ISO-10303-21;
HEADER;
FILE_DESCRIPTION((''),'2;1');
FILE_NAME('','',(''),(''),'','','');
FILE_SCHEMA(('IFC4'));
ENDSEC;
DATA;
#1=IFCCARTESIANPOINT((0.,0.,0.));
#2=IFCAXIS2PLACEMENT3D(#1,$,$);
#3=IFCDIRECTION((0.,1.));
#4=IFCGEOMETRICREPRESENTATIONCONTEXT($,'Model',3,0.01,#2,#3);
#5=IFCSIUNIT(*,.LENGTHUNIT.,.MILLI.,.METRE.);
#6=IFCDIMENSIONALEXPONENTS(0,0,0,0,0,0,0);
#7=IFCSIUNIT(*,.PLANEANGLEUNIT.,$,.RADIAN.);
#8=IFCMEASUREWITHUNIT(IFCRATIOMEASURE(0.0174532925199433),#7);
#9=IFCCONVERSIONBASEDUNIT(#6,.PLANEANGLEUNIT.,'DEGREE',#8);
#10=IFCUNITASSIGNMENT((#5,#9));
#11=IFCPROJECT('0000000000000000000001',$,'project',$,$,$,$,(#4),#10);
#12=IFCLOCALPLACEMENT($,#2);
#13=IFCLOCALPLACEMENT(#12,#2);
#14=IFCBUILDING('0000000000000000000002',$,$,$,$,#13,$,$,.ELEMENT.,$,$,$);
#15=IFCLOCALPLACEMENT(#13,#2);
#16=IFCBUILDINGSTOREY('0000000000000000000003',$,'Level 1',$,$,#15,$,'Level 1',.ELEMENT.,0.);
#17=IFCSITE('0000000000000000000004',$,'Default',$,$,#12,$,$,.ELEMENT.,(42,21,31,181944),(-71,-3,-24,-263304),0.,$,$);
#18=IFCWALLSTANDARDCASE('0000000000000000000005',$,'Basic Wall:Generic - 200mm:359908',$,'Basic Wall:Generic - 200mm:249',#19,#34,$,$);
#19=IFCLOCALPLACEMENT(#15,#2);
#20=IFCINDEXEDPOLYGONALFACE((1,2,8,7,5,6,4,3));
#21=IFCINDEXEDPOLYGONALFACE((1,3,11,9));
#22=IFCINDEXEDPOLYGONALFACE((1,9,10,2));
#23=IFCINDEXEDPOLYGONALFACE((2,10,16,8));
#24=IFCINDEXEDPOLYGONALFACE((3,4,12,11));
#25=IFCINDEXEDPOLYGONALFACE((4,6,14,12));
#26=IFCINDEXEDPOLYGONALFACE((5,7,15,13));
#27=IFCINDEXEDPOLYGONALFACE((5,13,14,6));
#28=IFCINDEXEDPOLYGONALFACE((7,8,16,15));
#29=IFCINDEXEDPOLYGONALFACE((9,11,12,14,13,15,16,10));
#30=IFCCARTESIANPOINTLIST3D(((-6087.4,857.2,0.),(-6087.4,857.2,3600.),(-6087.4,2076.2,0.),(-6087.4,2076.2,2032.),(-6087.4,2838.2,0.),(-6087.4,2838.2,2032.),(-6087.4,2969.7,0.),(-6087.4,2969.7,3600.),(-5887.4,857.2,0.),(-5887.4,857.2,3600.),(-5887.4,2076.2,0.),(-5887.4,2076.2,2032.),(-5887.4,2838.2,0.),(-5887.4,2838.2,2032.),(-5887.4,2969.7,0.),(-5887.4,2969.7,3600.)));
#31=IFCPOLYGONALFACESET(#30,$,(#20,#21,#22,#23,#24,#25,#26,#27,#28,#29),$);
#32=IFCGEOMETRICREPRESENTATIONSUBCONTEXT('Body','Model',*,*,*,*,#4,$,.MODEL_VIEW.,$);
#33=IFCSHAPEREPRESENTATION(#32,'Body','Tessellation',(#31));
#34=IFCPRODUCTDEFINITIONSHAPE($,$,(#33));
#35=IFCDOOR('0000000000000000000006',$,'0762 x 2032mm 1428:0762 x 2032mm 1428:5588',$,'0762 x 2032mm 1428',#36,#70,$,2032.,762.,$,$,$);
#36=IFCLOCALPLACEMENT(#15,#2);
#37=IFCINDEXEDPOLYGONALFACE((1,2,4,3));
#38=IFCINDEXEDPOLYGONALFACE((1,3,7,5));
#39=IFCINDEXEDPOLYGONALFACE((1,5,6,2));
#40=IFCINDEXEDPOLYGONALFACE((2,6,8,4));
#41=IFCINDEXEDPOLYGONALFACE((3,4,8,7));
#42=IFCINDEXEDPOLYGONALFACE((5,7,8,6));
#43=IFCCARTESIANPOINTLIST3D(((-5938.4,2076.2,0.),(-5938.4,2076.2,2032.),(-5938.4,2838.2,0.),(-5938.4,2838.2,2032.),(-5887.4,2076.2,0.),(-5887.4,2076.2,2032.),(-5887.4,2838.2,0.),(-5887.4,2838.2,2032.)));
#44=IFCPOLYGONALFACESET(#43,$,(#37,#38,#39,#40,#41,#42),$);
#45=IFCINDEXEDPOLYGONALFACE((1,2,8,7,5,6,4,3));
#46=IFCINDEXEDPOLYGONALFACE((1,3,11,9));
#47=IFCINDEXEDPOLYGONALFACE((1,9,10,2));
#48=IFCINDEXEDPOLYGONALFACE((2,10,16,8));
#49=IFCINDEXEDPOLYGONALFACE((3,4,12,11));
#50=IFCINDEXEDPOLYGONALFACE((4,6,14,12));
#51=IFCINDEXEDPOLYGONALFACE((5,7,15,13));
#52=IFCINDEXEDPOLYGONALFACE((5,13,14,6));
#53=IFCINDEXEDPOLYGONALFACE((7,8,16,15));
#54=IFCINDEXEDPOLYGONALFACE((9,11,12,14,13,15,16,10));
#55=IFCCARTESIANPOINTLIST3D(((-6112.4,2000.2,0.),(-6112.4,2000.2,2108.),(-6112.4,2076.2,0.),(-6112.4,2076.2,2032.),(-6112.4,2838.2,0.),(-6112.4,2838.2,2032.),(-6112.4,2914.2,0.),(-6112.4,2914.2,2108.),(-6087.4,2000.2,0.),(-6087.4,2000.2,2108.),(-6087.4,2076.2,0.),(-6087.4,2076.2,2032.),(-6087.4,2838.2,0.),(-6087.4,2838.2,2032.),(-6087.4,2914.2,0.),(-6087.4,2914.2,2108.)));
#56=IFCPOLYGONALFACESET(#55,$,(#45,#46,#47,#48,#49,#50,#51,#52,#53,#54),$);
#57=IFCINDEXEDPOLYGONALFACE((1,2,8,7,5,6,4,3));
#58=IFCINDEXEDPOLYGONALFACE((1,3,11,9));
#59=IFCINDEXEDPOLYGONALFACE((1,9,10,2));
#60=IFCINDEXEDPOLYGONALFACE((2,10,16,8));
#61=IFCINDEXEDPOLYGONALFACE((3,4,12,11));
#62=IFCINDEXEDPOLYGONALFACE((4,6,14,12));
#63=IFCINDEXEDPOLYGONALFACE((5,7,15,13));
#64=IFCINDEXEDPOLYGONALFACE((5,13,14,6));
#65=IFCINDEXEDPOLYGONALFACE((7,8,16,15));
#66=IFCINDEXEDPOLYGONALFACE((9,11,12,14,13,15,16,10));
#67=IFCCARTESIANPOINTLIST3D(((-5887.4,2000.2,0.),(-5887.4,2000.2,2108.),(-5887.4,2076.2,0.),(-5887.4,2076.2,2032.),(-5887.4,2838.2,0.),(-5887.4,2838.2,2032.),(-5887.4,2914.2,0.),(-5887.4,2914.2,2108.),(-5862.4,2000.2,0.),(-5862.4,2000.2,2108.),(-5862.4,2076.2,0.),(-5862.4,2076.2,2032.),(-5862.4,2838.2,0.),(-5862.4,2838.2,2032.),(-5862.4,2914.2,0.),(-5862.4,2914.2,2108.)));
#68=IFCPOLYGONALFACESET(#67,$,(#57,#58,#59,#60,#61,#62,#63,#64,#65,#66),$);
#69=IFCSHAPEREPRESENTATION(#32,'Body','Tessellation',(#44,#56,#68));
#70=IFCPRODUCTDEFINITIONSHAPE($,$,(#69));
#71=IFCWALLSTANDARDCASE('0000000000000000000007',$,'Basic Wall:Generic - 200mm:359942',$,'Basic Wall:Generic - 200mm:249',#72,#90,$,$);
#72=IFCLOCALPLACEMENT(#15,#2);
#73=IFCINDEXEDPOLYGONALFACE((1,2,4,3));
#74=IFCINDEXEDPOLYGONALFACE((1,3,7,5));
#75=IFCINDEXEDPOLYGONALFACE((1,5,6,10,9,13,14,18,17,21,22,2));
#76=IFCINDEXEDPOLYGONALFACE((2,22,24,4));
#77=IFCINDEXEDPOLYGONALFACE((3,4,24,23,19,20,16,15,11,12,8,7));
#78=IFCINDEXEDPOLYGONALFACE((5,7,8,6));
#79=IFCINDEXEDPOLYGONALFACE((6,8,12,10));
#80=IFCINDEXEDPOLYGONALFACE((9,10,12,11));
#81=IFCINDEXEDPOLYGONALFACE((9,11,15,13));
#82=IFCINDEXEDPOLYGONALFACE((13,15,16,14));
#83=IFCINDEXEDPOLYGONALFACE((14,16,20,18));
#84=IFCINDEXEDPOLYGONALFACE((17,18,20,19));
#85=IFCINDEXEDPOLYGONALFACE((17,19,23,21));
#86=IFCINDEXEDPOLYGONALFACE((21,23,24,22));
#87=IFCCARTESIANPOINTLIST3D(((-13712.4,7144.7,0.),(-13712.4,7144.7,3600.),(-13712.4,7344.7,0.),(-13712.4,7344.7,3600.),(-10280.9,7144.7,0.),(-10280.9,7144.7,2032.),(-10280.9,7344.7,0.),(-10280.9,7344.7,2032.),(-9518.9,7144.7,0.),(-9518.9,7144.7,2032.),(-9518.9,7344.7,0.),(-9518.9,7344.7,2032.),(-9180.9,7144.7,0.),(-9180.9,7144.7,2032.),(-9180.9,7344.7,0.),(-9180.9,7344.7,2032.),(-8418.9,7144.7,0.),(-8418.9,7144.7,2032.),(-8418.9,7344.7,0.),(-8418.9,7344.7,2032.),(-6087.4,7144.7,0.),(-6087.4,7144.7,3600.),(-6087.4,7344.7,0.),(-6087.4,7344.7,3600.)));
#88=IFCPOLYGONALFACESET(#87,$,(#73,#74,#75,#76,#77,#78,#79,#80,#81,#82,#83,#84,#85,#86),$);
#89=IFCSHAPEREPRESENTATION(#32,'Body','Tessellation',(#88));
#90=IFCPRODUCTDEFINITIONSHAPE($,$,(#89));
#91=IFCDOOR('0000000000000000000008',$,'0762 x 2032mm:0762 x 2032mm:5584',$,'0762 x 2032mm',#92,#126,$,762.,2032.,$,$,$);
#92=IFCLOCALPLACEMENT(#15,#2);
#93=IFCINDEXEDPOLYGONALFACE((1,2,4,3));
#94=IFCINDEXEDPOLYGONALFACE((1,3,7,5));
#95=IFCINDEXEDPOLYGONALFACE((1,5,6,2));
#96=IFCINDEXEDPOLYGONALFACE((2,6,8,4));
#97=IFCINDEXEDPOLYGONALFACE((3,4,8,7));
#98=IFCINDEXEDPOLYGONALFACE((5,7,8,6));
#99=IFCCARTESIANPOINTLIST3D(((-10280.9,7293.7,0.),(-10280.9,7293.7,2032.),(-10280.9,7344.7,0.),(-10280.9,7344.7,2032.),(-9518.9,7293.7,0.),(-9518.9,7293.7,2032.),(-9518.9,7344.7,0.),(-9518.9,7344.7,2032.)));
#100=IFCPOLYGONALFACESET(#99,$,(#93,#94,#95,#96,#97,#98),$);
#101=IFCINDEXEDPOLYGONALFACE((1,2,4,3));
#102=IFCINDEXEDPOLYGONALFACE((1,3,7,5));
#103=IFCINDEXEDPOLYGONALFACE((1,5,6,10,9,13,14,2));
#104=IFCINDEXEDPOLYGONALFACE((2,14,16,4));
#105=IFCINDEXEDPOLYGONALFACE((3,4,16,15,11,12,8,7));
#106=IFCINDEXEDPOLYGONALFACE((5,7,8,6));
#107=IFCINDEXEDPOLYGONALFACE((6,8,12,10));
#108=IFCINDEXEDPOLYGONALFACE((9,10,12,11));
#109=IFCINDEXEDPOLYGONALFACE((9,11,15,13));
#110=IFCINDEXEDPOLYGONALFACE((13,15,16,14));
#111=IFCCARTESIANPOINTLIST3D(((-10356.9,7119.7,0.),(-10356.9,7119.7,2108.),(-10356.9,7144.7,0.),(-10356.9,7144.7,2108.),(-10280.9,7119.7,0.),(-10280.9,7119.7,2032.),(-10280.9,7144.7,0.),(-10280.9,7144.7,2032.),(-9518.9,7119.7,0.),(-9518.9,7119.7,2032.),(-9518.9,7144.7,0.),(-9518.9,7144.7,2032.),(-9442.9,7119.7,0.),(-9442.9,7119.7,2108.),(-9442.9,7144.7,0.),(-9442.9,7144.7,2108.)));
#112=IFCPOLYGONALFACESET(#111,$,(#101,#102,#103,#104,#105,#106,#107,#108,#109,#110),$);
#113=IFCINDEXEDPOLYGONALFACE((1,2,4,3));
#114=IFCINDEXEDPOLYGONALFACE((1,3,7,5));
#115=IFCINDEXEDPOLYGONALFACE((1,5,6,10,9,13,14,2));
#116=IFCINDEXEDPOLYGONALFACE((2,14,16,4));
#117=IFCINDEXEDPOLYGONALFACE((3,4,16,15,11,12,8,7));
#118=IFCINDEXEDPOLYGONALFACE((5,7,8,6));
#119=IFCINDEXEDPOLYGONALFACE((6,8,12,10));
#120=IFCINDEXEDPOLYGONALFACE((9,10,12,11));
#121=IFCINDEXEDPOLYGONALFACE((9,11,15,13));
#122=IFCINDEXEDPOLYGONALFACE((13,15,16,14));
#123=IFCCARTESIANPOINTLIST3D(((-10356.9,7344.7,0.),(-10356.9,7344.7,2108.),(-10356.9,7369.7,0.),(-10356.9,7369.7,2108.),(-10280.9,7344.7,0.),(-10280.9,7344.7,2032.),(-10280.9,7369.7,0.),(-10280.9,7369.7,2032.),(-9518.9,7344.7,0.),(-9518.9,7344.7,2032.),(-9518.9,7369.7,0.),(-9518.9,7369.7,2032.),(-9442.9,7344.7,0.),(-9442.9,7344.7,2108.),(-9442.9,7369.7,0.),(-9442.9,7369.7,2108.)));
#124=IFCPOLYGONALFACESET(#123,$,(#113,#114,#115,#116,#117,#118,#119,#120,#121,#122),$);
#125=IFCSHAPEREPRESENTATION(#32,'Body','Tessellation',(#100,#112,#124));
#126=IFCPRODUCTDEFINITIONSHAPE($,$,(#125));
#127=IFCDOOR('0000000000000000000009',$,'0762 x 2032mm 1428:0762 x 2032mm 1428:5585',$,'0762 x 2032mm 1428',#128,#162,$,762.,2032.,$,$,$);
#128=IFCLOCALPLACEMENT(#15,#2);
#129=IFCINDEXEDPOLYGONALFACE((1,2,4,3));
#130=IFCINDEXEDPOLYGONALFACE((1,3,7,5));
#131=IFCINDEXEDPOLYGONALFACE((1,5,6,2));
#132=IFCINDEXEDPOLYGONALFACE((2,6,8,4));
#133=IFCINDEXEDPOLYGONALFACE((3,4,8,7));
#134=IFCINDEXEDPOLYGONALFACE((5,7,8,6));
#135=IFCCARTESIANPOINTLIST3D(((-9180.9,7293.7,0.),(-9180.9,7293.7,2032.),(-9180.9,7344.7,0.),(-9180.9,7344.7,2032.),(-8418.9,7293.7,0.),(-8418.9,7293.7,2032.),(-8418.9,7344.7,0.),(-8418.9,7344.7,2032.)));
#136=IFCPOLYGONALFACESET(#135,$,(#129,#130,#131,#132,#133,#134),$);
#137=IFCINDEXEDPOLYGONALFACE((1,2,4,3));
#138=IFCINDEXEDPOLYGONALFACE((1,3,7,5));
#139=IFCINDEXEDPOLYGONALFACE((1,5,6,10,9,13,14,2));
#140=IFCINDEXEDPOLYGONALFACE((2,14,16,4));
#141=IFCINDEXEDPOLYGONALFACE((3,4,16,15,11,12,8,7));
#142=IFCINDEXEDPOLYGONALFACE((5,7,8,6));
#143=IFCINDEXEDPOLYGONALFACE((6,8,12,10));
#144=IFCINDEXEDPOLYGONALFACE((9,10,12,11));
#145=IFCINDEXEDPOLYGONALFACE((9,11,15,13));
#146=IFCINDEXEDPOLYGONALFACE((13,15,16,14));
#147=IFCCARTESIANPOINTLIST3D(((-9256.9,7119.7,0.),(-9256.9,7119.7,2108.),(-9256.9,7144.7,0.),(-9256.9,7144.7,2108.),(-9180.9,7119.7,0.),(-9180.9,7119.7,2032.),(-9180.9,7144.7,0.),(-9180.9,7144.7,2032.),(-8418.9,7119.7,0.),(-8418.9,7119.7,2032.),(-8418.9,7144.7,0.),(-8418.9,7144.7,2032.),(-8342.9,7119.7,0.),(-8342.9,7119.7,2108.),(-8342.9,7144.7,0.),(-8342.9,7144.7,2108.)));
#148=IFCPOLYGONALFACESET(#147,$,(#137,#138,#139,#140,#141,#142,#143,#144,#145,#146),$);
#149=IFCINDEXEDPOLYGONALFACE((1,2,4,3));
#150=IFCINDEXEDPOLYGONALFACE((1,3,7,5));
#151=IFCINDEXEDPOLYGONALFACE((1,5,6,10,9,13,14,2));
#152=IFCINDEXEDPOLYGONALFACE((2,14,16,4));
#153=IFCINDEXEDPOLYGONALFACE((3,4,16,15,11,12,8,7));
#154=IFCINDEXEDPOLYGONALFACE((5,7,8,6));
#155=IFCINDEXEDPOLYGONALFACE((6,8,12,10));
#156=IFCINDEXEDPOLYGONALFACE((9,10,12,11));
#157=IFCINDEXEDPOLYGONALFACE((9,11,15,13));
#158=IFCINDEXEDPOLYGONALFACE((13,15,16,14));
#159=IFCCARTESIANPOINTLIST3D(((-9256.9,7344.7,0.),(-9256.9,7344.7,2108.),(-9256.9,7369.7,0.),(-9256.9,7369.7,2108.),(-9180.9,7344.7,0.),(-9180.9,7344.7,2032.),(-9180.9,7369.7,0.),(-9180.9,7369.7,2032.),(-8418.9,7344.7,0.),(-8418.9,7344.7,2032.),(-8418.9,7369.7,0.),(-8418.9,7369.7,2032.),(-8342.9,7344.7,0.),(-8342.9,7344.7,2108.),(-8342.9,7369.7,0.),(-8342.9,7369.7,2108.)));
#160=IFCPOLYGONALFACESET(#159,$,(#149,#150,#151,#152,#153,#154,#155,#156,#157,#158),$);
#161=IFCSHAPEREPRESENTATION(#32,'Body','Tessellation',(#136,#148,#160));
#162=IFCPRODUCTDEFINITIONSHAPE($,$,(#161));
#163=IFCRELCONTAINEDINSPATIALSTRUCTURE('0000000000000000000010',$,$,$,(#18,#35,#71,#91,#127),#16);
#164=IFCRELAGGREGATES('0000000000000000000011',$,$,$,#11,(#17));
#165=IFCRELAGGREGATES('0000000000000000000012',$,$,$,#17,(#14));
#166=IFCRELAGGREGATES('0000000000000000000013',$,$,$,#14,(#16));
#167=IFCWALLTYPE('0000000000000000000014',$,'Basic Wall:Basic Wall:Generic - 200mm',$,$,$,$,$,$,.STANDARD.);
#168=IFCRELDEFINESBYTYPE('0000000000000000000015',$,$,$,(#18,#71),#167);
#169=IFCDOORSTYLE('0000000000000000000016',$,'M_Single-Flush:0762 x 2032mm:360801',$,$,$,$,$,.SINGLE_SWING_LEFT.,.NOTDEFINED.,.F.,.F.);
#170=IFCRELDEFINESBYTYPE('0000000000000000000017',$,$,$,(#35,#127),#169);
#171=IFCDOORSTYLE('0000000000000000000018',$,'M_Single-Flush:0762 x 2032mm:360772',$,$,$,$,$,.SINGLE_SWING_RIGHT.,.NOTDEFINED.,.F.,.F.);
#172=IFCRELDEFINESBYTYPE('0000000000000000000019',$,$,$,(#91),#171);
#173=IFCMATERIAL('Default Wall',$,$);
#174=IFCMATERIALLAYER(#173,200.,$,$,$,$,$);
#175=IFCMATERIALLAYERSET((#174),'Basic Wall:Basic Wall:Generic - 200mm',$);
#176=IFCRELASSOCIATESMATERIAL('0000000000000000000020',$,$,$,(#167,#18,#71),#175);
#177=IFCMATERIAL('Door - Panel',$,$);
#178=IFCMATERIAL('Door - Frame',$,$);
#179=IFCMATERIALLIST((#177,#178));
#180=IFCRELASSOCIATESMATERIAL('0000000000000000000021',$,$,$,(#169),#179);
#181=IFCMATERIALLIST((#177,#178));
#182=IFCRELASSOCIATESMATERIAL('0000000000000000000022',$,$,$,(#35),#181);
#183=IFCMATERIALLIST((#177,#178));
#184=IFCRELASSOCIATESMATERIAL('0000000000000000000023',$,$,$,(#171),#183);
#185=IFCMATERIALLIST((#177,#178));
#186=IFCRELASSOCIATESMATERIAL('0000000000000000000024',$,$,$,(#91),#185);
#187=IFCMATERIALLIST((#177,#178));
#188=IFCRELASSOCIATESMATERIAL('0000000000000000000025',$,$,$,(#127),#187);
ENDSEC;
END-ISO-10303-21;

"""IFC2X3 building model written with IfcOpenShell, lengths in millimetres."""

from ifc_helpers import new_model, entity, si_unit, converted_unit, direction, frame, frame_2d, origin, origin_2d_with_axis, place, context, subcontext, project, spatial, polyline, rectangle, outline, extrude, source, transform, mapped, material, material_list, layer, layer_set, layer_usage, type_object, type_shapes, element, fill, save


model = new_model("IFC2X3")

# Units and contexts
model_context = context("Model", 3, precision=0.01, world=origin(), true_north=direction((0.0, 1.0)))
body_context = subcontext(model_context, "Body", "Model", "MODEL_VIEW")
ifc_project = project(units=[si_unit("LENGTHUNIT", "METRE", prefix="MILLI"), converted_unit("PLANEANGLEUNIT", "DEGREE", entity("IfcRatioMeasure", 0.0174532925199433), si_unit("PLANEANGLEUNIT", "RADIAN"), dimensions=[0, 0, 0, 0, 0, 0, 0])], contexts=[model_context])

# Site, building, storey
site_placement = place(None, origin())
site = spatial("IfcSite", under=ifc_project, at=site_placement, Name="Default", CompositionType="ELEMENT", RefLatitude=(42, 21, 31, 181944), RefLongitude=(-71, -3, -24, -263304), RefElevation=0.0)
building_placement = place(site_placement, origin())
building = spatial("IfcBuilding", under=site, at=building_placement, CompositionType="ELEMENT")
storey_placement = place(building_placement, origin())
storey = spatial("IfcBuildingStorey", under=building, at=storey_placement, Name="Level 1", LongName="Level 1", CompositionType="ELEMENT", Elevation=0.0)

# Shared definitions
ifc_material_1 = material(Name="Default Wall")
ifc_material_2 = material(Name="Door - Panel")
ifc_material_3 = material(Name="Door - Frame")

# Wall, opening, door
ifc_layer_1 = layer(ifc_material_1, 200.0)
ifc_layer_set_1 = layer_set([ifc_layer_1], Name="Basic Wall:Basic Wall:Generic - 200mm")
ifc_layer_usage_1 = layer_usage(ifc_layer_set_1, "AXIS2", "NEGATIVE", 100.0)
wall_type_1 = type_object("IfcWallType", Name="Basic Wall:Basic Wall:Generic - 200mm", PredefinedType="STANDARD", material=ifc_layer_set_1)
wall_1_placement = place(storey_placement, frame((-5987.4, 857.2, 0.0), z_axis=(0.0, 0.0, 1.0), x_axis=(0.0, 1.0, 0.0)))
wall_1 = element("IfcWallStandardCase", 1, at=wall_1_placement, inside=storey, type_object=wall_type_1, material=ifc_layer_usage_1, Name="Basic Wall:Generic - 200mm:359908", ObjectType="Basic Wall:Generic - 200mm:249", context=body_context, shape_type="SweptSolid", body=[
    extrude(rectangle(XDim=2112.5, YDim=200.0, at=frame_2d((1056.2, 0.0), x_axis=(-1.0, 0.0))), origin(), (0.0, 0.0, 1.0), 3600.0),
])
opening_1_placement = place(wall_1_placement, frame((-857.2, -5987.4, 0.0), z_axis=(0.0, 0.0, 1.0), x_axis=(0.0, -1.0, 0.0)))
opening_1 = element("IfcOpeningElement", 2, at=opening_1_placement, cuts=wall_1, ObjectType="Opening", context=body_context, shape_type="SweptSolid", body=[
    extrude(rectangle(XDim=2032.0, YDim=762.0, at=frame_2d((0.0, 0.0), x_axis=(0.0, 1.0))), frame((-5885.4, 2457.2, 1016.0), z_axis=(-1.0, 0.0, 0.0), x_axis=(0.0, -1.0, 0.0)), (0.0, 0.0, 1.0), 204.0),
])
ifc_material_list_1 = material_list([ifc_material_2, ifc_material_3])
ifc_material_list_2 = material_list([ifc_material_2, ifc_material_3])
door_style_1 = type_object("IfcDoorStyle", Name="M_Single-Flush:0762 x 2032mm:360801", ConstructionType="NOTDEFINED", OperationType="SINGLE_SWING_LEFT", ParameterTakesPrecedence=False, Sizeable=False, material=ifc_material_list_2)
shared_shape_1 = source(origin(), body_context, "Body", "SweptSolid", [
    extrude(rectangle(XDim=51.0, YDim=762.0, at=origin_2d_with_axis()), frame((381.0, -27.5, 0.0), z_axis=(0.0, 0.0, 1.0), x_axis=(0.0, 1.0, 0.0)), (0.0, 0.0, 1.0), 2032.0),
    extrude(outline(polyline([(-1035.0, -457.0), (1073.0, -457.0), (1073.0, 457.0), (-1035.0, 457.0), (-1035.0, 381.0), (997.0, 381.0), (997.0, -381.0), (-1035.0, -381.0), (-1035.0, -457.0)])), frame((381.0, -227.0, 1035.0), z_axis=(0.0, 1.0, 0.0), x_axis=(0.0, 0.0, 1.0)), (0.0, 0.0, 1.0), 25.0),
    extrude(outline(polyline([(-457.0, -1073.0), (457.0, -1073.0), (457.0, 1035.0), (381.0, 1035.0), (381.0, -997.0), (-381.0, -997.0), (-381.0, 1035.0), (-457.0, 1035.0), (-457.0, -1073.0)])), frame((381.0, -2.0, 1035.0), z_axis=(0.0, 1.0, 0.0), x_axis=(1.0, 0.0, 0.0)), (0.0, 0.0, 1.0), 25.0),
])
type_shapes(door_style_1, [shared_shape_1])
door_1_placement = place(opening_1_placement, frame((-5885.4, 2838.2, 0.0), z_axis=(0.0, 0.0, 1.0), x_axis=(0.0, -1.0, 0.0)))
door_1 = element("IfcDoor", 3, at=door_1_placement, inside=storey, type_object=door_style_1, material=ifc_material_list_1, Name="0762 x 2032mm 1428:0762 x 2032mm 1428:5588", ObjectType="0762 x 2032mm 1428", OverallHeight=2032.0, OverallWidth=762.0, context=body_context, shape_type="MappedRepresentation", body=[
    mapped(shared_shape_1, transform((0.0, 0.0, 0.0), scale=1.0)),
])
fill(opening_1, door_1)

# Wall, openings, doors
ifc_layer_usage_2 = layer_usage(ifc_layer_set_1, "AXIS2", "NEGATIVE", 100.0)
wall_2_placement = place(storey_placement, frame((-13712.4, 7244.7, 0.0)))
wall_2 = element("IfcWallStandardCase", 4, at=wall_2_placement, inside=storey, type_object=wall_type_1, material=ifc_layer_usage_2, Name="Basic Wall:Generic - 200mm:359942", ObjectType="Basic Wall:Generic - 200mm:249", context=body_context, shape_type="SweptSolid", body=[
    extrude(rectangle(XDim=7625.0, YDim=200.0, at=frame_2d((3812.5, 0.0), x_axis=(-1.0, 0.0))), origin(), (0.0, 0.0, 1.0), 3600.0),
])
opening_2_placement = place(wall_2_placement, frame((13712.4, -7244.7, 0.0)))
opening_2 = element("IfcOpeningElement", 5, at=opening_2_placement, cuts=wall_2, ObjectType="Opening", context=body_context, shape_type="SweptSolid", body=[
    extrude(rectangle(XDim=2032.0, YDim=762.0, at=origin_2d_with_axis()), frame((-9899.9, 7142.7, 1016.0), z_axis=(0.0, 1.0, 0.0), x_axis=(0.0, 0.0, -1.0)), (0.0, 0.0, 1.0), 204.0),
])
opening_3_placement = place(wall_2_placement, frame((13712.4, -7244.7, 0.0)))
opening_3 = element("IfcOpeningElement", 6, at=opening_3_placement, cuts=wall_2, ObjectType="Opening", context=body_context, shape_type="SweptSolid", body=[
    extrude(rectangle(XDim=2032.0, YDim=762.0, at=origin_2d_with_axis()), frame((-8799.9, 7142.7, 1016.0), z_axis=(0.0, 1.0, 0.0), x_axis=(0.0, 0.0, 1.0)), (0.0, 0.0, 1.0), 204.0),
])
ifc_material_list_3 = material_list([ifc_material_2, ifc_material_3])
ifc_material_list_4 = material_list([ifc_material_2, ifc_material_3])
door_style_2 = type_object("IfcDoorStyle", Name="M_Single-Flush:0762 x 2032mm:360772", ConstructionType="NOTDEFINED", OperationType="SINGLE_SWING_RIGHT", ParameterTakesPrecedence=False, Sizeable=False, material=ifc_material_list_4)
shared_shape_2 = source(origin(), body_context, "Body", "SweptSolid", [
    extrude(rectangle(XDim=762.0, YDim=51.0, at=frame_2d((0.0, 0.0), x_axis=(1.0, 0.0))), frame((381.0, -27.5, 0.0), z_axis=(0.0, 0.0, 1.0), x_axis=(-1.0, 0.0, 0.0)), (0.0, 0.0, 1.0), 2032.0),
    extrude(outline(polyline([(-457.0, -1035.0), (-381.0, -1035.0), (-381.0, 997.0), (381.0, 997.0), (381.0, -1035.0), (457.0, -1035.0), (457.0, 1073.0), (-457.0, 1073.0), (-457.0, -1035.0)])), frame((381.0, -227.0, 1035.0), z_axis=(0.0, 1.0, 0.0), x_axis=(-1.0, 0.0, 0.0)), (0.0, 0.0, 1.0), 25.0),
    extrude(outline(polyline([(-1073.0, -457.0), (1035.0, -457.0), (1035.0, -381.0), (-997.0, -381.0), (-997.0, 381.0), (1035.0, 381.0), (1035.0, 457.0), (-1073.0, 457.0), (-1073.0, -457.0)])), frame((381.0, -2.0, 1035.0), z_axis=(0.0, 1.0, 0.0), x_axis=(0.0, 0.0, -1.0)), (0.0, 0.0, 1.0), 25.0),
])
type_shapes(door_style_2, [shared_shape_2])
door_2_placement = place(opening_2_placement, frame((-10280.9, 7346.7, 0.0)))
door_2 = element("IfcDoor", 7, at=door_2_placement, inside=storey, type_object=door_style_2, material=ifc_material_list_3, Name="0762 x 2032mm:0762 x 2032mm:5584", ObjectType="0762 x 2032mm", OverallHeight=762.0, OverallWidth=2032.0, context=body_context, shape_type="MappedRepresentation", body=[
    mapped(shared_shape_2, transform((0.0, 0.0, 0.0), scale=1.0)),
])
fill(opening_2, door_2)
ifc_material_list_5 = material_list([ifc_material_2, ifc_material_3])
door_3_placement = place(opening_3_placement, frame((-9180.9, 7346.7, 0.0)))
door_3 = element("IfcDoor", 8, at=door_3_placement, inside=storey, type_object=door_style_1, material=ifc_material_list_5, Name="0762 x 2032mm 1428:0762 x 2032mm 1428:5585", ObjectType="0762 x 2032mm 1428", OverallHeight=762.0, OverallWidth=2032.0, context=body_context, shape_type="MappedRepresentation", body=[
    mapped(shared_shape_1, transform((0.0, 0.0, 0.0), scale=1.0)),
])
fill(opening_3, door_3)

save(model, "model.ifc")
